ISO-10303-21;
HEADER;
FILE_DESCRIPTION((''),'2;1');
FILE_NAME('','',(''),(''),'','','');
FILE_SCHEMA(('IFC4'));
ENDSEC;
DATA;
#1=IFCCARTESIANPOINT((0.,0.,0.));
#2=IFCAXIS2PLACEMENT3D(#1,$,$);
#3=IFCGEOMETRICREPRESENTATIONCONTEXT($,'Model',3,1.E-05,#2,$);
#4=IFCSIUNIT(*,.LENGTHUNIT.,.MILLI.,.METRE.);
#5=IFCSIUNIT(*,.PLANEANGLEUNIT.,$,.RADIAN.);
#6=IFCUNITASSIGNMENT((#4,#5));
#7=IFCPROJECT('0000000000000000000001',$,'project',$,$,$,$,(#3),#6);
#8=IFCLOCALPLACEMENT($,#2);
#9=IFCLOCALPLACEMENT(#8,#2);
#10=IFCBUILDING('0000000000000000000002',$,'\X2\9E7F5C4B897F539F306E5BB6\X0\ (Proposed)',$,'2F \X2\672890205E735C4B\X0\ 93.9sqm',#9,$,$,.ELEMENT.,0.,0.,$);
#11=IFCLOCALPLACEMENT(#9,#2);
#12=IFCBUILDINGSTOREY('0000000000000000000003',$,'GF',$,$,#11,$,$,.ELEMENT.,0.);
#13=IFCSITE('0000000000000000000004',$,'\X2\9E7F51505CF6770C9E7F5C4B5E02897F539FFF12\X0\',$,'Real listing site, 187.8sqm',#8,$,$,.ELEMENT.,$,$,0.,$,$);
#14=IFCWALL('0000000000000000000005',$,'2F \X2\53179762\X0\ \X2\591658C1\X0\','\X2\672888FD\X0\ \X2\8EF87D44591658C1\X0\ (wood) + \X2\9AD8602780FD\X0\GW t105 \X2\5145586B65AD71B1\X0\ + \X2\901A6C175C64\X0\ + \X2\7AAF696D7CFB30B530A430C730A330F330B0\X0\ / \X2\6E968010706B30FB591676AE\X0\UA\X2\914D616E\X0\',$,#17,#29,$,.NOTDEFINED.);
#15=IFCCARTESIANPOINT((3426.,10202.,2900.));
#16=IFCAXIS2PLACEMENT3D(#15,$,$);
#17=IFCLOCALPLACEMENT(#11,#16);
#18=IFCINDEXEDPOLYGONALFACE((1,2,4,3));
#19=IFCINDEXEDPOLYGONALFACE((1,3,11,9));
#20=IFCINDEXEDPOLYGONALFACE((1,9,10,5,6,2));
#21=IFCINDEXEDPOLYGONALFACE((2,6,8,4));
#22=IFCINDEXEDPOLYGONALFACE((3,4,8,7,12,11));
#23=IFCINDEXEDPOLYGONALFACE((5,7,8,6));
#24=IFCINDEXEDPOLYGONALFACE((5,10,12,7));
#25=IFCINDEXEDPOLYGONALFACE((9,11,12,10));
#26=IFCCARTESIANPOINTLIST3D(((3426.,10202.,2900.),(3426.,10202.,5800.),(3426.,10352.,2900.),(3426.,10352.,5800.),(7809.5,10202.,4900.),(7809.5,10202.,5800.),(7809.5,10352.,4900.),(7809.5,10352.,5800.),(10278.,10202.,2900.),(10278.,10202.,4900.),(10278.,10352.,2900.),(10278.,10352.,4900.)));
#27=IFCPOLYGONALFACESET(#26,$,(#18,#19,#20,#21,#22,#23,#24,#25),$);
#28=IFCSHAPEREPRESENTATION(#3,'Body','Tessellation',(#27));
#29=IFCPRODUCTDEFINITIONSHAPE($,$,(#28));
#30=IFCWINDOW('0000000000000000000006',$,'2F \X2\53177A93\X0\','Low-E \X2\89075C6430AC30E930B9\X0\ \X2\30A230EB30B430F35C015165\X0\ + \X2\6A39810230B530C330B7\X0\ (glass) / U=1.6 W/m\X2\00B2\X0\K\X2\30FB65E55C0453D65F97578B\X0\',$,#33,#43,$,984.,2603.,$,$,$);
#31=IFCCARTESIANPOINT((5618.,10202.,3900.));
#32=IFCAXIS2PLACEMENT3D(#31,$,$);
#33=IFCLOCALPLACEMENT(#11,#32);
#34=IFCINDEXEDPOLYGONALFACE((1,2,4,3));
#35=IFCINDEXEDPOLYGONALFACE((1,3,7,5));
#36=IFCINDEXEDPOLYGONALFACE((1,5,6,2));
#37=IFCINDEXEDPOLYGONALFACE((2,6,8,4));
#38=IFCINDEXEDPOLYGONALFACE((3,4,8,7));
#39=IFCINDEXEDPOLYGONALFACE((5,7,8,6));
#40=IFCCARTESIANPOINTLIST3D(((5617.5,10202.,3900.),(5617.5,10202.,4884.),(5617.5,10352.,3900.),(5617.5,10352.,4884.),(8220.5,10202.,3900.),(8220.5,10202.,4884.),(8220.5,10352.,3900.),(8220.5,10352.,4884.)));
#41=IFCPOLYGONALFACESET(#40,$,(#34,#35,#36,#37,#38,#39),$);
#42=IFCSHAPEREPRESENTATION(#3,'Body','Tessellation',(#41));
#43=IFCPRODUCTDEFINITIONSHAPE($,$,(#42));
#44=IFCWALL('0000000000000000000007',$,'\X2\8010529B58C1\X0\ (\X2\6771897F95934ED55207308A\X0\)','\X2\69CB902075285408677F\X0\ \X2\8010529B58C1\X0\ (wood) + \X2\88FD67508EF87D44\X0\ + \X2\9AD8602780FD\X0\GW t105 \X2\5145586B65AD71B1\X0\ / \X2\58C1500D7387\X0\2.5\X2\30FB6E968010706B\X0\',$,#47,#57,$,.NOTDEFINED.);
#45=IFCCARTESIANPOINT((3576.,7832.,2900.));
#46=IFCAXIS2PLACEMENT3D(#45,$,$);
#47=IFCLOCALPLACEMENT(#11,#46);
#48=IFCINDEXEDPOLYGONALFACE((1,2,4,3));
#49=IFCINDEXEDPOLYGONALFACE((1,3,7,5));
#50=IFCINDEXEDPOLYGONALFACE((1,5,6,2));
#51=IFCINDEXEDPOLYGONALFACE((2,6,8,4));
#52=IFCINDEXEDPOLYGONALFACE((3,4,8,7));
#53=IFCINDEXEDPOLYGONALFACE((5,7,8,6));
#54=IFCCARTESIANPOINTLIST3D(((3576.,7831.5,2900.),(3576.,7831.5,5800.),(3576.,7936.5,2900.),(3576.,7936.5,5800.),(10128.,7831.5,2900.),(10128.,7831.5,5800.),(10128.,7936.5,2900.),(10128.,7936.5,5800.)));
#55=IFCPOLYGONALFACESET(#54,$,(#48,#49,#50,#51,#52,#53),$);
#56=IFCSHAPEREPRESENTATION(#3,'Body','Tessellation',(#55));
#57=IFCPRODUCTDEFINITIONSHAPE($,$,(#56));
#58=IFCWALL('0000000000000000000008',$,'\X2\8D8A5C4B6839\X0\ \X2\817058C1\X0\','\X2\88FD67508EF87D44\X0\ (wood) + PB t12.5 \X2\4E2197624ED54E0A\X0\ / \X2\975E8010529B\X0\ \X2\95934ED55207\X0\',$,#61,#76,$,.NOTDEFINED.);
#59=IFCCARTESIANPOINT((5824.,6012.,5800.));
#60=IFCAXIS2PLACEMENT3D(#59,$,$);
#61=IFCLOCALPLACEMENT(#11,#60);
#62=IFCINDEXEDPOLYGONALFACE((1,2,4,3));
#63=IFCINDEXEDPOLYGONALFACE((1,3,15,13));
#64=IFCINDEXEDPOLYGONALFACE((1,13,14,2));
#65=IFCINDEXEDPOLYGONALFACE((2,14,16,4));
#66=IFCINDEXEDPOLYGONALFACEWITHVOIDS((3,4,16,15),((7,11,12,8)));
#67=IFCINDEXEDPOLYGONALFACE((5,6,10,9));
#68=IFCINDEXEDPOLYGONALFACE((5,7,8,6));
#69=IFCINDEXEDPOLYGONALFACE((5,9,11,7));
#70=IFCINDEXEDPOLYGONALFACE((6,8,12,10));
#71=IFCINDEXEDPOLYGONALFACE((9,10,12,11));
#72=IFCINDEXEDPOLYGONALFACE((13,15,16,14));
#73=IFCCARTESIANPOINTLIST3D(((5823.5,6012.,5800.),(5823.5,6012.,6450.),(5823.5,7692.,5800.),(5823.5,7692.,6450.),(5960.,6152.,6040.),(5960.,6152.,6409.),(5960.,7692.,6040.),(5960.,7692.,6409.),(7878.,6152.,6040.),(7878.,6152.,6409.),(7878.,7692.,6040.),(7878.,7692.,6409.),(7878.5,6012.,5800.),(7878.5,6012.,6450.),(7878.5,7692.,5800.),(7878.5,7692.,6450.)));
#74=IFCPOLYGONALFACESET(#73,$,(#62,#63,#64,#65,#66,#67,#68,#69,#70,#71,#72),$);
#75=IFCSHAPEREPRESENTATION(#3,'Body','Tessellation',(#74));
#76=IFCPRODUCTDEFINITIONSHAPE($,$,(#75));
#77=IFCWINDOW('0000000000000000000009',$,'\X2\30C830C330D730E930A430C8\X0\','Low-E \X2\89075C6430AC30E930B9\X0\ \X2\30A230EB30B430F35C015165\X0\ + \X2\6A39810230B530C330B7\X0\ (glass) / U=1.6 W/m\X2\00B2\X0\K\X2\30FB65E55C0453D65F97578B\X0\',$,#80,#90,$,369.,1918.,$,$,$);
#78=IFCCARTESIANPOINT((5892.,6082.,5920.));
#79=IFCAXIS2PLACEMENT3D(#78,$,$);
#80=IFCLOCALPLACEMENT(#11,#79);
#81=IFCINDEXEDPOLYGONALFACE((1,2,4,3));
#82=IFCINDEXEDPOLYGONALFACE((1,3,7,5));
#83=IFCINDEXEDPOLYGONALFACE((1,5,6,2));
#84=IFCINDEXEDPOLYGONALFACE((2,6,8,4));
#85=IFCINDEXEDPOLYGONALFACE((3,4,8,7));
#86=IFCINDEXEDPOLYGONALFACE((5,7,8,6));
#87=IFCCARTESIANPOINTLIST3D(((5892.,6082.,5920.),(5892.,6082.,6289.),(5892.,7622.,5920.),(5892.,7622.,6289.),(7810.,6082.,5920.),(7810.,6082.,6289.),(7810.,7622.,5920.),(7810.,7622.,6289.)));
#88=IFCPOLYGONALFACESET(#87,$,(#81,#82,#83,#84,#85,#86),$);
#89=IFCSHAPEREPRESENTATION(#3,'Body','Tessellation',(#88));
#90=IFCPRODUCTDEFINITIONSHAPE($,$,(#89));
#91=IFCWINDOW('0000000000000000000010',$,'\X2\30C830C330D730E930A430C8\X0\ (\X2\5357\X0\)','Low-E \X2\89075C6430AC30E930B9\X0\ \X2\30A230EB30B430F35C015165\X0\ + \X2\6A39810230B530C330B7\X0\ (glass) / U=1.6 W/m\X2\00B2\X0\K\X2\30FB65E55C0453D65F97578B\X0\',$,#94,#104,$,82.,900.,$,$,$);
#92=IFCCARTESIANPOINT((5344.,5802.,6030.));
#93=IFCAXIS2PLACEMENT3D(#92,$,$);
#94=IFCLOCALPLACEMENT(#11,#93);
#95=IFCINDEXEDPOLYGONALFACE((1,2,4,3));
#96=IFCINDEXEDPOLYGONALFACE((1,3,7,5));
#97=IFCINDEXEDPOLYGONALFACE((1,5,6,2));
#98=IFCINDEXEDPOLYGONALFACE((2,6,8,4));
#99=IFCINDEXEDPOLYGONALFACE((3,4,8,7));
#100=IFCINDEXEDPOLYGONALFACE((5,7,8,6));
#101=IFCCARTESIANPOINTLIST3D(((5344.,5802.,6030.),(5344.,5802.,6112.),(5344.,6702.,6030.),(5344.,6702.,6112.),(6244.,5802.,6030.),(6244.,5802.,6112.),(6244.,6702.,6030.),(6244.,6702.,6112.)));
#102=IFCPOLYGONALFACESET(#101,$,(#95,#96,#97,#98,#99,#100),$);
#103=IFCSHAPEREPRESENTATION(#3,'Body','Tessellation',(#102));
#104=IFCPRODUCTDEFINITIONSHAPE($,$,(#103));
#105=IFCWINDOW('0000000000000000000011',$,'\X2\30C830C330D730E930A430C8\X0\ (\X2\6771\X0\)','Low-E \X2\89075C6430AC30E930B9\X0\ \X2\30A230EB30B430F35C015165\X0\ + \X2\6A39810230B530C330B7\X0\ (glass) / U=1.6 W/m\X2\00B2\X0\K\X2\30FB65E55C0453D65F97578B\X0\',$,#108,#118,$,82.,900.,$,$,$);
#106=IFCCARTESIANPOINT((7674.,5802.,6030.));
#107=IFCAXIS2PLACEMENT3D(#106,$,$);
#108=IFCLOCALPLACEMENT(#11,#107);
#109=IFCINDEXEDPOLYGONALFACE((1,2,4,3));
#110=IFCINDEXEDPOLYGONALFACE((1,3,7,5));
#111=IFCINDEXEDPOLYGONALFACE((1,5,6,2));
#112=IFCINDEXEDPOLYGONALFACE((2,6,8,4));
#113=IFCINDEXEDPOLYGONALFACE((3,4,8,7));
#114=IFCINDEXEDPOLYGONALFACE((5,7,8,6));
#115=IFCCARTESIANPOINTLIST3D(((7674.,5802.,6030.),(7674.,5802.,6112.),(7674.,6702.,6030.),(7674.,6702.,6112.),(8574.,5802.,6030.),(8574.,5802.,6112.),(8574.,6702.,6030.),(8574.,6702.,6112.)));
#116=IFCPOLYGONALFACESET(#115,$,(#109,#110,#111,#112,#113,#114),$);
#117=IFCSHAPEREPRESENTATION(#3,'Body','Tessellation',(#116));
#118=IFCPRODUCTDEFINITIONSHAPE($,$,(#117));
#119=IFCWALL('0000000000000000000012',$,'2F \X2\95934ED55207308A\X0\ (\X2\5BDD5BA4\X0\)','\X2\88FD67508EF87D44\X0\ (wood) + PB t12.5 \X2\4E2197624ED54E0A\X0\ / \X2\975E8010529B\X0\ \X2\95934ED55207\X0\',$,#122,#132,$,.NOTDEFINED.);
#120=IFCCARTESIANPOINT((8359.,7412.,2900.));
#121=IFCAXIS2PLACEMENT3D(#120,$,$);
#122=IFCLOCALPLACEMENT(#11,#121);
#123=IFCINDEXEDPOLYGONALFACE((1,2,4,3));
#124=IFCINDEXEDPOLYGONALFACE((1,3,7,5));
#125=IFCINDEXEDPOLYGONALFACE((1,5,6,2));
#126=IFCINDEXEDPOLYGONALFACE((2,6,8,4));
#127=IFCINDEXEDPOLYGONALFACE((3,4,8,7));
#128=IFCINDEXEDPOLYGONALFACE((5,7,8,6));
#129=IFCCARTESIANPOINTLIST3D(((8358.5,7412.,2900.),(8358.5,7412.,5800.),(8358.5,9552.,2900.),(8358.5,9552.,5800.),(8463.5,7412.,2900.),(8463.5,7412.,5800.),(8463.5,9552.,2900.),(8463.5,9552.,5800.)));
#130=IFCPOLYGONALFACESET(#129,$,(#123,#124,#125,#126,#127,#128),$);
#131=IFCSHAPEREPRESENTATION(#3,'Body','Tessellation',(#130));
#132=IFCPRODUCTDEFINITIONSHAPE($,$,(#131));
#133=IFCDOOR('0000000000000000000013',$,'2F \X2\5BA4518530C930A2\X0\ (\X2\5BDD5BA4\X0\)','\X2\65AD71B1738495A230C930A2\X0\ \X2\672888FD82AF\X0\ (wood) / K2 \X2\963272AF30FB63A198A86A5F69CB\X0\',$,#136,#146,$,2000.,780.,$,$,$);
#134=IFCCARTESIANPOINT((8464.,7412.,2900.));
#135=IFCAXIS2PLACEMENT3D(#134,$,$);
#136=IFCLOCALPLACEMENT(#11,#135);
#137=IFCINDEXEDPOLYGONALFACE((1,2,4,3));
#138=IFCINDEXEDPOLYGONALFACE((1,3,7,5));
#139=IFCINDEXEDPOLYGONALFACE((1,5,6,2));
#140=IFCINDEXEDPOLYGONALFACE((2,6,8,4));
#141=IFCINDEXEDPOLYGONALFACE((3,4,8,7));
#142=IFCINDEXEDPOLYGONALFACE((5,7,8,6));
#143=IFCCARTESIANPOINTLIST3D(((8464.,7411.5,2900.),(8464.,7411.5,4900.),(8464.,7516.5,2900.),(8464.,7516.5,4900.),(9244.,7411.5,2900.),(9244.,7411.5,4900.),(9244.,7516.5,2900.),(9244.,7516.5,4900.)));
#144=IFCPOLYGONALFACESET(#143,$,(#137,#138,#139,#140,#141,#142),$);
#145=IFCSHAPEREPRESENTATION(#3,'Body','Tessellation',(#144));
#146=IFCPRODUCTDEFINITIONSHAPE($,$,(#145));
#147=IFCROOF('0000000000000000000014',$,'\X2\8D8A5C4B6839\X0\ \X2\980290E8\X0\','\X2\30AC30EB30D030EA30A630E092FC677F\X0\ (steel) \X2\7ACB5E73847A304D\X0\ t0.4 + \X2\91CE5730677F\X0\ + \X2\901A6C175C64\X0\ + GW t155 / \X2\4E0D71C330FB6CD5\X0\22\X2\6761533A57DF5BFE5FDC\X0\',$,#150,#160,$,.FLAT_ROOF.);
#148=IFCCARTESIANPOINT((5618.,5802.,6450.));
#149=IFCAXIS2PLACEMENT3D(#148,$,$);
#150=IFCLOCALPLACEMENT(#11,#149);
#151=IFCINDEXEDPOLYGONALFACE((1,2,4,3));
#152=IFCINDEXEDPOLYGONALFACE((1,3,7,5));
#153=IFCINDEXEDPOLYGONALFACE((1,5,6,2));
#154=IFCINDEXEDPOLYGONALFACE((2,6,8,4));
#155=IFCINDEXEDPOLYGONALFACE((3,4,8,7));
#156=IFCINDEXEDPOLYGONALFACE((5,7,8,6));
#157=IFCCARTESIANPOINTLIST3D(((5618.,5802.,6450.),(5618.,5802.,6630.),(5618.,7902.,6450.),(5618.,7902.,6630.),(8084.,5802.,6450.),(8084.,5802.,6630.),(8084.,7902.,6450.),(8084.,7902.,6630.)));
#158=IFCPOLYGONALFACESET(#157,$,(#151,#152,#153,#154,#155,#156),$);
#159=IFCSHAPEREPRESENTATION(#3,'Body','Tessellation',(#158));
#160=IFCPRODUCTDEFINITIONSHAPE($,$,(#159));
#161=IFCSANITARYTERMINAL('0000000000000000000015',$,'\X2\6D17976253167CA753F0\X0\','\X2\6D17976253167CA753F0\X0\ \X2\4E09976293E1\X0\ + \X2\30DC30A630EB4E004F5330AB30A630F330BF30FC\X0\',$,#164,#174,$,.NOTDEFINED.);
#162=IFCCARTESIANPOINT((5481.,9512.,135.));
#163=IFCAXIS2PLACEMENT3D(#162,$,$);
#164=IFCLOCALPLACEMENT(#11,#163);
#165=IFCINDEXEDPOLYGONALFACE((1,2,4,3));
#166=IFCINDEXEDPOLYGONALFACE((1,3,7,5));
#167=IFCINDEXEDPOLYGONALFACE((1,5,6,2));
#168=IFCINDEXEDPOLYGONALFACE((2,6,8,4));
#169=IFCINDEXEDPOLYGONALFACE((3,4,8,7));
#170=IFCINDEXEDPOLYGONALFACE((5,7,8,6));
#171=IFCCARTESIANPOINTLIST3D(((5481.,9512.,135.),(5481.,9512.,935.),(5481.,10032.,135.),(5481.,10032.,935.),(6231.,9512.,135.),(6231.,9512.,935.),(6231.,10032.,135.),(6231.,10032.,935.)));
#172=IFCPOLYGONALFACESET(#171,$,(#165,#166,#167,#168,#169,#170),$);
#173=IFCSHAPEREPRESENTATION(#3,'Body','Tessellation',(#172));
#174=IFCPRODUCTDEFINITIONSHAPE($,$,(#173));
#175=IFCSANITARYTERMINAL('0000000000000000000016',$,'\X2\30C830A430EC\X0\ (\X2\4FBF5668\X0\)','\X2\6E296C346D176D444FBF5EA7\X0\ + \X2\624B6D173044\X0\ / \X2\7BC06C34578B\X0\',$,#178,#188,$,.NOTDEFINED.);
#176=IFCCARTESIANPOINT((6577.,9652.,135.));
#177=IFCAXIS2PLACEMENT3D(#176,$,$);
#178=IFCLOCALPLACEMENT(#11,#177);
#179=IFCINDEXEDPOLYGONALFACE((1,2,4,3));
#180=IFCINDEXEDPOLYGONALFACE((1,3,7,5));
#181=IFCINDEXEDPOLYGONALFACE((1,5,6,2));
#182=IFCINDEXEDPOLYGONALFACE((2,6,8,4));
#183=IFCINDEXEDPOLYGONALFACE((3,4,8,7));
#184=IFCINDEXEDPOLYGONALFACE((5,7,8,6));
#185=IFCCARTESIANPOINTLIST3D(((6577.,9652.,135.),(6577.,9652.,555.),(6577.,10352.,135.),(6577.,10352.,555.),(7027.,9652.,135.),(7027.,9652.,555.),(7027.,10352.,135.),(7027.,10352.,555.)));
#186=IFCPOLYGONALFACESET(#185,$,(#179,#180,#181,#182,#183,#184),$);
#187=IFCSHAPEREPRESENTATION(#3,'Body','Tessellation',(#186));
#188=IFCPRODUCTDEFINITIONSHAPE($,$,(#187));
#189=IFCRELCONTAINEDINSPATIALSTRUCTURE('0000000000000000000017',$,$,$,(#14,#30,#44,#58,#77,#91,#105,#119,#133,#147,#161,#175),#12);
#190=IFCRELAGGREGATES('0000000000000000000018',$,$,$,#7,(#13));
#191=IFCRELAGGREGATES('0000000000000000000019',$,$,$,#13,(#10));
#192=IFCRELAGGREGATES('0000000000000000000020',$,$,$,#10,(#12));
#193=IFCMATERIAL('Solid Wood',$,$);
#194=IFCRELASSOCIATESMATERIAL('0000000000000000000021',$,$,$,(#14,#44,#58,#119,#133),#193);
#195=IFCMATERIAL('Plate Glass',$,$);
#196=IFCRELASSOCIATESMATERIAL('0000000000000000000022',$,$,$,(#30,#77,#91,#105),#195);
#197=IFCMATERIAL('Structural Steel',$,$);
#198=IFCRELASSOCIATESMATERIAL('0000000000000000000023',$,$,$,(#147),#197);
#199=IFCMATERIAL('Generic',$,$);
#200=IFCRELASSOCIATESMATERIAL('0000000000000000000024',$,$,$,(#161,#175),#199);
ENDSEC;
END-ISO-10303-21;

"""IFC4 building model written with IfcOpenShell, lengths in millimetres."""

from ifc_helpers import new_model, si_unit, frame, frame_2d, origin, place, context, project, spatial, rectangle, extrude, material, element, fill, save


model = new_model("IFC4")

# Units and contexts
model_context = context("Model", 3, precision=1e-05, world=origin())
ifc_project = project(units=[si_unit("LENGTHUNIT", "METRE", prefix="MILLI"), si_unit("PLANEANGLEUNIT", "RADIAN")], contexts=[model_context])

# Site, building, storey
site_placement = place(None, origin())
site = spatial("IfcSite", under=ifc_project, at=site_placement, Name="鹿児島県鹿屋市西原２", ObjectType="Real listing site, 187.8sqm", CompositionType="ELEMENT", RefElevation=0.0)
building_placement = place(site_placement, origin())
building = spatial("IfcBuilding", under=site, at=building_placement, Name="鹿屋西原の家 (Proposed)", ObjectType="2F 木造平屋 93.9sqm", CompositionType="ELEMENT", ElevationOfRefHeight=0.0, ElevationOfTerrain=0.0)
storey_placement = place(building_placement, origin())
storey = spatial("IfcBuildingStorey", under=building, at=storey_placement, Name="GF", CompositionType="ELEMENT", Elevation=0.0)

# Wall, opening, window
ifc_material_1 = material(Name="Solid Wood")
wall_1_placement = place(storey_placement, frame((3426.0, 10202.0, 2900.0)))
wall_1 = element("IfcWall", 1, at=wall_1_placement, inside=storey, material=ifc_material_1, Name="2F 北面 外壁", Description="木製 軸組外壁 (wood) + 高性能GW t105 充填断熱 + 通気層 + 窯業系サイディング / 準耐火・外皮UA配慮", PredefinedType="NOTDEFINED", context=model_context, shape_type="SweptSolid", body=[
    extrude(rectangle(XDim=6852.0, YDim=150.0, at=frame_2d((3426.0, 75.0))), frame((3426.0, 10202.0, 2900.0)), (0.0, 0.0, 1.0), 2900.0),
])
opening_1_placement = place(storey_placement, frame((5618.0, 10202.0, 3900.0)))
opening_1 = element("IfcOpeningElement", 2, at=opening_1_placement, cuts=wall_1, PredefinedType="NOTDEFINED", context=model_context, shape_type="SweptSolid", body=[
    extrude(rectangle(XDim=2603.0, YDim=150.0, at=frame_2d((1301.0, 75.0))), frame((5618.0, 10202.0, 3900.0)), (0.0, 0.0, 1.0), 984.0),
])
ifc_material_2 = material(Name="Plate Glass")
window_1_placement = place(storey_placement, frame((5618.0, 10202.0, 3900.0)))
window_1 = element("IfcWindow", 3, at=window_1_placement, inside=storey, material=ifc_material_2, Name="2F 北窓", Description="Low-E 複層ガラス アルゴン封入 + 樹脂サッシ (glass) / U=1.6 W/m²K・日射取得型", OverallHeight=984.0, OverallWidth=2603.0, context=model_context, shape_type="SweptSolid", body=[
    extrude(rectangle(XDim=2603.0, YDim=150.0, at=frame_2d((1301.0, 75.0))), frame((5618.0, 10202.0, 3900.0)), (0.0, 0.0, 1.0), 984.0),
])
fill(opening_1, window_1)

# Wall
wall_2_placement = place(storey_placement, frame((3576.0, 7832.0, 2900.0)))
element("IfcWall", 4, at=wall_2_placement, inside=storey, material=ifc_material_1, Name="耐力壁 (東西間仕切り)", Description="構造用合板 耐力壁 (wood) + 製材軸組 + 高性能GW t105 充填断熱 / 壁倍率2.5・準耐火", PredefinedType="NOTDEFINED", context=model_context, shape_type="SweptSolid", body=[
    extrude(rectangle(XDim=6552.0, YDim=105.0, at=frame_2d((3276.0, 52.0))), frame((3576.0, 7832.0, 2900.0)), (0.0, 0.0, 1.0), 2900.0),
])

# Wall, openings, windows
wall_3_placement = place(storey_placement, frame((5824.0, 6012.0, 5800.0)))
wall_3 = element("IfcWall", 5, at=wall_3_placement, inside=storey, material=ifc_material_1, Name="越屋根 腰壁", Description="製材軸組 (wood) + PB t12.5 両面仕上 / 非耐力 間仕切", PredefinedType="NOTDEFINED", context=model_context, shape_type="SweptSolid", body=[
    extrude(rectangle(XDim=2055.0, YDim=1680.0, at=frame_2d((1027.0, 840.0))), frame((5824.0, 6012.0, 5800.0)), (0.0, 0.0, 1.0), 650.0),
])
opening_2_placement = place(storey_placement, frame((5892.0, 6082.0, 5920.0)))
opening_2 = element("IfcOpeningElement", 6, at=opening_2_placement, cuts=wall_3, PredefinedType="NOTDEFINED", context=model_context, shape_type="SweptSolid", body=[
    extrude(rectangle(XDim=1918.0, YDim=1540.0, at=frame_2d((959.0, 770.0))), frame((5892.0, 6082.0, 5920.0)), (0.0, 0.0, 1.0), 369.0),
])
opening_3_placement = place(storey_placement, frame((5344.0, 5802.0, 6030.0)))
opening_3 = element("IfcOpeningElement", 7, at=opening_3_placement, cuts=wall_3, PredefinedType="NOTDEFINED", context=model_context, shape_type="SweptSolid", body=[
    extrude(rectangle(XDim=900.0, YDim=900.0, at=frame_2d((450.0, 450.0))), frame((5344.0, 5802.0, 6030.0)), (0.0, 0.0, 1.0), 82.0),
])
opening_4_placement = place(storey_placement, frame((7674.0, 5802.0, 6030.0)))
opening_4 = element("IfcOpeningElement", 8, at=opening_4_placement, cuts=wall_3, PredefinedType="NOTDEFINED", context=model_context, shape_type="SweptSolid", body=[
    extrude(rectangle(XDim=900.0, YDim=900.0, at=frame_2d((450.0, 450.0))), frame((7674.0, 5802.0, 6030.0)), (0.0, 0.0, 1.0), 82.0),
])
window_2_placement = place(storey_placement, frame((5892.0, 6082.0, 5920.0)))
window_2 = element("IfcWindow", 9, at=window_2_placement, inside=storey, material=ifc_material_2, Name="トップライト", Description="Low-E 複層ガラス アルゴン封入 + 樹脂サッシ (glass) / U=1.6 W/m²K・日射取得型", OverallHeight=369.0, OverallWidth=1918.0, context=model_context, shape_type="SweptSolid", body=[
    extrude(rectangle(XDim=1918.0, YDim=1540.0, at=frame_2d((959.0, 770.0))), frame((5892.0, 6082.0, 5920.0)), (0.0, 0.0, 1.0), 369.0),
])
fill(opening_2, window_2)
window_3_placement = place(storey_placement, frame((5344.0, 5802.0, 6030.0)))
window_3 = element("IfcWindow", 10, at=window_3_placement, inside=storey, material=ifc_material_2, Name="トップライト (南)", Description="Low-E 複層ガラス アルゴン封入 + 樹脂サッシ (glass) / U=1.6 W/m²K・日射取得型", OverallHeight=82.0, OverallWidth=900.0, context=model_context, shape_type="SweptSolid", body=[
    extrude(rectangle(XDim=900.0, YDim=900.0, at=frame_2d((450.0, 450.0))), frame((5344.0, 5802.0, 6030.0)), (0.0, 0.0, 1.0), 82.0),
])
fill(opening_3, window_3)
window_4_placement = place(storey_placement, frame((7674.0, 5802.0, 6030.0)))
window_4 = element("IfcWindow", 11, at=window_4_placement, inside=storey, material=ifc_material_2, Name="トップライト (東)", Description="Low-E 複層ガラス アルゴン封入 + 樹脂サッシ (glass) / U=1.6 W/m²K・日射取得型", OverallHeight=82.0, OverallWidth=900.0, context=model_context, shape_type="SweptSolid", body=[
    extrude(rectangle(XDim=900.0, YDim=900.0, at=frame_2d((450.0, 450.0))), frame((7674.0, 5802.0, 6030.0)), (0.0, 0.0, 1.0), 82.0),
])
fill(opening_4, window_4)

# Wall
wall_4_placement = place(storey_placement, frame((8359.0, 7412.0, 2900.0)))
element("IfcWall", 12, at=wall_4_placement, inside=storey, material=ifc_material_1, Name="2F 間仕切り (寝室)", Description="製材軸組 (wood) + PB t12.5 両面仕上 / 非耐力 間仕切", PredefinedType="NOTDEFINED", context=model_context, shape_type="SweptSolid", body=[
    extrude(rectangle(XDim=105.0, YDim=2140.0, at=frame_2d((52.0, 1070.0))), frame((8359.0, 7412.0, 2900.0)), (0.0, 0.0, 1.0), 2900.0),
])

# Door
door_placement = place(storey_placement, frame((8464.0, 7412.0, 2900.0)))
element("IfcDoor", 13, at=door_placement, inside=storey, material=ifc_material_1, Name="2F 室内ドア (寝室)", Description="断熱玄関ドア 木製芯 (wood) / K2 防犯・採風機構", OverallHeight=2000.0, OverallWidth=780.0, context=model_context, shape_type="SweptSolid", body=[
    extrude(rectangle(XDim=780.0, YDim=105.0, at=frame_2d((390.0, 52.0))), frame((8464.0, 7412.0, 2900.0)), (0.0, 0.0, 1.0), 2000.0),
])

# Roof
ifc_material_3 = material(Name="Structural Steel")
roof_placement = place(storey_placement, frame((5618.0, 5802.0, 6450.0)))
element("IfcRoof", 14, at=roof_placement, inside=storey, material=ifc_material_3, Name="越屋根 頂部", Description="ガルバリウム鋼板 (steel) 立平葺き t0.4 + 野地板 + 通気層 + GW t155 / 不燃・法22条区域対応", PredefinedType="FLAT_ROOF", context=model_context, shape_type="SweptSolid", body=[
    extrude(rectangle(XDim=2466.0, YDim=2100.0, at=frame_2d((1233.0, 1050.0))), frame((5618.0, 5802.0, 6450.0)), (0.0, 0.0, 1.0), 180.0),
])

# Sanitary terminals
ifc_material_4 = material(Name="Generic")
sanitary_terminal_1_placement = place(storey_placement, frame((5481.0, 9512.0, 135.0)))
element("IfcSanitaryTerminal", 15, at=sanitary_terminal_1_placement, inside=storey, material=ifc_material_4, Name="洗面化粧台", Description="洗面化粧台 三面鏡 + ボウル一体カウンター", PredefinedType="NOTDEFINED", context=model_context, shape_type="SweptSolid", body=[
    extrude(rectangle(XDim=750.0, YDim=520.0, at=frame_2d((375.0, 260.0))), frame((5481.0, 9512.0, 135.0)), (0.0, 0.0, 1.0), 800.0),
])
sanitary_terminal_2_placement = place(storey_placement, frame((6577.0, 9652.0, 135.0)))
element("IfcSanitaryTerminal", 16, at=sanitary_terminal_2_placement, inside=storey, material=ifc_material_4, Name="トイレ (便器)", Description="温水洗浄便座 + 手洗い / 節水型", PredefinedType="NOTDEFINED", context=model_context, shape_type="SweptSolid", body=[
    extrude(rectangle(XDim=450.0, YDim=700.0, at=frame_2d((225.0, 350.0))), frame((6577.0, 9652.0, 135.0)), (0.0, 0.0, 1.0), 420.0),
])

save(model, "model.ifc")
